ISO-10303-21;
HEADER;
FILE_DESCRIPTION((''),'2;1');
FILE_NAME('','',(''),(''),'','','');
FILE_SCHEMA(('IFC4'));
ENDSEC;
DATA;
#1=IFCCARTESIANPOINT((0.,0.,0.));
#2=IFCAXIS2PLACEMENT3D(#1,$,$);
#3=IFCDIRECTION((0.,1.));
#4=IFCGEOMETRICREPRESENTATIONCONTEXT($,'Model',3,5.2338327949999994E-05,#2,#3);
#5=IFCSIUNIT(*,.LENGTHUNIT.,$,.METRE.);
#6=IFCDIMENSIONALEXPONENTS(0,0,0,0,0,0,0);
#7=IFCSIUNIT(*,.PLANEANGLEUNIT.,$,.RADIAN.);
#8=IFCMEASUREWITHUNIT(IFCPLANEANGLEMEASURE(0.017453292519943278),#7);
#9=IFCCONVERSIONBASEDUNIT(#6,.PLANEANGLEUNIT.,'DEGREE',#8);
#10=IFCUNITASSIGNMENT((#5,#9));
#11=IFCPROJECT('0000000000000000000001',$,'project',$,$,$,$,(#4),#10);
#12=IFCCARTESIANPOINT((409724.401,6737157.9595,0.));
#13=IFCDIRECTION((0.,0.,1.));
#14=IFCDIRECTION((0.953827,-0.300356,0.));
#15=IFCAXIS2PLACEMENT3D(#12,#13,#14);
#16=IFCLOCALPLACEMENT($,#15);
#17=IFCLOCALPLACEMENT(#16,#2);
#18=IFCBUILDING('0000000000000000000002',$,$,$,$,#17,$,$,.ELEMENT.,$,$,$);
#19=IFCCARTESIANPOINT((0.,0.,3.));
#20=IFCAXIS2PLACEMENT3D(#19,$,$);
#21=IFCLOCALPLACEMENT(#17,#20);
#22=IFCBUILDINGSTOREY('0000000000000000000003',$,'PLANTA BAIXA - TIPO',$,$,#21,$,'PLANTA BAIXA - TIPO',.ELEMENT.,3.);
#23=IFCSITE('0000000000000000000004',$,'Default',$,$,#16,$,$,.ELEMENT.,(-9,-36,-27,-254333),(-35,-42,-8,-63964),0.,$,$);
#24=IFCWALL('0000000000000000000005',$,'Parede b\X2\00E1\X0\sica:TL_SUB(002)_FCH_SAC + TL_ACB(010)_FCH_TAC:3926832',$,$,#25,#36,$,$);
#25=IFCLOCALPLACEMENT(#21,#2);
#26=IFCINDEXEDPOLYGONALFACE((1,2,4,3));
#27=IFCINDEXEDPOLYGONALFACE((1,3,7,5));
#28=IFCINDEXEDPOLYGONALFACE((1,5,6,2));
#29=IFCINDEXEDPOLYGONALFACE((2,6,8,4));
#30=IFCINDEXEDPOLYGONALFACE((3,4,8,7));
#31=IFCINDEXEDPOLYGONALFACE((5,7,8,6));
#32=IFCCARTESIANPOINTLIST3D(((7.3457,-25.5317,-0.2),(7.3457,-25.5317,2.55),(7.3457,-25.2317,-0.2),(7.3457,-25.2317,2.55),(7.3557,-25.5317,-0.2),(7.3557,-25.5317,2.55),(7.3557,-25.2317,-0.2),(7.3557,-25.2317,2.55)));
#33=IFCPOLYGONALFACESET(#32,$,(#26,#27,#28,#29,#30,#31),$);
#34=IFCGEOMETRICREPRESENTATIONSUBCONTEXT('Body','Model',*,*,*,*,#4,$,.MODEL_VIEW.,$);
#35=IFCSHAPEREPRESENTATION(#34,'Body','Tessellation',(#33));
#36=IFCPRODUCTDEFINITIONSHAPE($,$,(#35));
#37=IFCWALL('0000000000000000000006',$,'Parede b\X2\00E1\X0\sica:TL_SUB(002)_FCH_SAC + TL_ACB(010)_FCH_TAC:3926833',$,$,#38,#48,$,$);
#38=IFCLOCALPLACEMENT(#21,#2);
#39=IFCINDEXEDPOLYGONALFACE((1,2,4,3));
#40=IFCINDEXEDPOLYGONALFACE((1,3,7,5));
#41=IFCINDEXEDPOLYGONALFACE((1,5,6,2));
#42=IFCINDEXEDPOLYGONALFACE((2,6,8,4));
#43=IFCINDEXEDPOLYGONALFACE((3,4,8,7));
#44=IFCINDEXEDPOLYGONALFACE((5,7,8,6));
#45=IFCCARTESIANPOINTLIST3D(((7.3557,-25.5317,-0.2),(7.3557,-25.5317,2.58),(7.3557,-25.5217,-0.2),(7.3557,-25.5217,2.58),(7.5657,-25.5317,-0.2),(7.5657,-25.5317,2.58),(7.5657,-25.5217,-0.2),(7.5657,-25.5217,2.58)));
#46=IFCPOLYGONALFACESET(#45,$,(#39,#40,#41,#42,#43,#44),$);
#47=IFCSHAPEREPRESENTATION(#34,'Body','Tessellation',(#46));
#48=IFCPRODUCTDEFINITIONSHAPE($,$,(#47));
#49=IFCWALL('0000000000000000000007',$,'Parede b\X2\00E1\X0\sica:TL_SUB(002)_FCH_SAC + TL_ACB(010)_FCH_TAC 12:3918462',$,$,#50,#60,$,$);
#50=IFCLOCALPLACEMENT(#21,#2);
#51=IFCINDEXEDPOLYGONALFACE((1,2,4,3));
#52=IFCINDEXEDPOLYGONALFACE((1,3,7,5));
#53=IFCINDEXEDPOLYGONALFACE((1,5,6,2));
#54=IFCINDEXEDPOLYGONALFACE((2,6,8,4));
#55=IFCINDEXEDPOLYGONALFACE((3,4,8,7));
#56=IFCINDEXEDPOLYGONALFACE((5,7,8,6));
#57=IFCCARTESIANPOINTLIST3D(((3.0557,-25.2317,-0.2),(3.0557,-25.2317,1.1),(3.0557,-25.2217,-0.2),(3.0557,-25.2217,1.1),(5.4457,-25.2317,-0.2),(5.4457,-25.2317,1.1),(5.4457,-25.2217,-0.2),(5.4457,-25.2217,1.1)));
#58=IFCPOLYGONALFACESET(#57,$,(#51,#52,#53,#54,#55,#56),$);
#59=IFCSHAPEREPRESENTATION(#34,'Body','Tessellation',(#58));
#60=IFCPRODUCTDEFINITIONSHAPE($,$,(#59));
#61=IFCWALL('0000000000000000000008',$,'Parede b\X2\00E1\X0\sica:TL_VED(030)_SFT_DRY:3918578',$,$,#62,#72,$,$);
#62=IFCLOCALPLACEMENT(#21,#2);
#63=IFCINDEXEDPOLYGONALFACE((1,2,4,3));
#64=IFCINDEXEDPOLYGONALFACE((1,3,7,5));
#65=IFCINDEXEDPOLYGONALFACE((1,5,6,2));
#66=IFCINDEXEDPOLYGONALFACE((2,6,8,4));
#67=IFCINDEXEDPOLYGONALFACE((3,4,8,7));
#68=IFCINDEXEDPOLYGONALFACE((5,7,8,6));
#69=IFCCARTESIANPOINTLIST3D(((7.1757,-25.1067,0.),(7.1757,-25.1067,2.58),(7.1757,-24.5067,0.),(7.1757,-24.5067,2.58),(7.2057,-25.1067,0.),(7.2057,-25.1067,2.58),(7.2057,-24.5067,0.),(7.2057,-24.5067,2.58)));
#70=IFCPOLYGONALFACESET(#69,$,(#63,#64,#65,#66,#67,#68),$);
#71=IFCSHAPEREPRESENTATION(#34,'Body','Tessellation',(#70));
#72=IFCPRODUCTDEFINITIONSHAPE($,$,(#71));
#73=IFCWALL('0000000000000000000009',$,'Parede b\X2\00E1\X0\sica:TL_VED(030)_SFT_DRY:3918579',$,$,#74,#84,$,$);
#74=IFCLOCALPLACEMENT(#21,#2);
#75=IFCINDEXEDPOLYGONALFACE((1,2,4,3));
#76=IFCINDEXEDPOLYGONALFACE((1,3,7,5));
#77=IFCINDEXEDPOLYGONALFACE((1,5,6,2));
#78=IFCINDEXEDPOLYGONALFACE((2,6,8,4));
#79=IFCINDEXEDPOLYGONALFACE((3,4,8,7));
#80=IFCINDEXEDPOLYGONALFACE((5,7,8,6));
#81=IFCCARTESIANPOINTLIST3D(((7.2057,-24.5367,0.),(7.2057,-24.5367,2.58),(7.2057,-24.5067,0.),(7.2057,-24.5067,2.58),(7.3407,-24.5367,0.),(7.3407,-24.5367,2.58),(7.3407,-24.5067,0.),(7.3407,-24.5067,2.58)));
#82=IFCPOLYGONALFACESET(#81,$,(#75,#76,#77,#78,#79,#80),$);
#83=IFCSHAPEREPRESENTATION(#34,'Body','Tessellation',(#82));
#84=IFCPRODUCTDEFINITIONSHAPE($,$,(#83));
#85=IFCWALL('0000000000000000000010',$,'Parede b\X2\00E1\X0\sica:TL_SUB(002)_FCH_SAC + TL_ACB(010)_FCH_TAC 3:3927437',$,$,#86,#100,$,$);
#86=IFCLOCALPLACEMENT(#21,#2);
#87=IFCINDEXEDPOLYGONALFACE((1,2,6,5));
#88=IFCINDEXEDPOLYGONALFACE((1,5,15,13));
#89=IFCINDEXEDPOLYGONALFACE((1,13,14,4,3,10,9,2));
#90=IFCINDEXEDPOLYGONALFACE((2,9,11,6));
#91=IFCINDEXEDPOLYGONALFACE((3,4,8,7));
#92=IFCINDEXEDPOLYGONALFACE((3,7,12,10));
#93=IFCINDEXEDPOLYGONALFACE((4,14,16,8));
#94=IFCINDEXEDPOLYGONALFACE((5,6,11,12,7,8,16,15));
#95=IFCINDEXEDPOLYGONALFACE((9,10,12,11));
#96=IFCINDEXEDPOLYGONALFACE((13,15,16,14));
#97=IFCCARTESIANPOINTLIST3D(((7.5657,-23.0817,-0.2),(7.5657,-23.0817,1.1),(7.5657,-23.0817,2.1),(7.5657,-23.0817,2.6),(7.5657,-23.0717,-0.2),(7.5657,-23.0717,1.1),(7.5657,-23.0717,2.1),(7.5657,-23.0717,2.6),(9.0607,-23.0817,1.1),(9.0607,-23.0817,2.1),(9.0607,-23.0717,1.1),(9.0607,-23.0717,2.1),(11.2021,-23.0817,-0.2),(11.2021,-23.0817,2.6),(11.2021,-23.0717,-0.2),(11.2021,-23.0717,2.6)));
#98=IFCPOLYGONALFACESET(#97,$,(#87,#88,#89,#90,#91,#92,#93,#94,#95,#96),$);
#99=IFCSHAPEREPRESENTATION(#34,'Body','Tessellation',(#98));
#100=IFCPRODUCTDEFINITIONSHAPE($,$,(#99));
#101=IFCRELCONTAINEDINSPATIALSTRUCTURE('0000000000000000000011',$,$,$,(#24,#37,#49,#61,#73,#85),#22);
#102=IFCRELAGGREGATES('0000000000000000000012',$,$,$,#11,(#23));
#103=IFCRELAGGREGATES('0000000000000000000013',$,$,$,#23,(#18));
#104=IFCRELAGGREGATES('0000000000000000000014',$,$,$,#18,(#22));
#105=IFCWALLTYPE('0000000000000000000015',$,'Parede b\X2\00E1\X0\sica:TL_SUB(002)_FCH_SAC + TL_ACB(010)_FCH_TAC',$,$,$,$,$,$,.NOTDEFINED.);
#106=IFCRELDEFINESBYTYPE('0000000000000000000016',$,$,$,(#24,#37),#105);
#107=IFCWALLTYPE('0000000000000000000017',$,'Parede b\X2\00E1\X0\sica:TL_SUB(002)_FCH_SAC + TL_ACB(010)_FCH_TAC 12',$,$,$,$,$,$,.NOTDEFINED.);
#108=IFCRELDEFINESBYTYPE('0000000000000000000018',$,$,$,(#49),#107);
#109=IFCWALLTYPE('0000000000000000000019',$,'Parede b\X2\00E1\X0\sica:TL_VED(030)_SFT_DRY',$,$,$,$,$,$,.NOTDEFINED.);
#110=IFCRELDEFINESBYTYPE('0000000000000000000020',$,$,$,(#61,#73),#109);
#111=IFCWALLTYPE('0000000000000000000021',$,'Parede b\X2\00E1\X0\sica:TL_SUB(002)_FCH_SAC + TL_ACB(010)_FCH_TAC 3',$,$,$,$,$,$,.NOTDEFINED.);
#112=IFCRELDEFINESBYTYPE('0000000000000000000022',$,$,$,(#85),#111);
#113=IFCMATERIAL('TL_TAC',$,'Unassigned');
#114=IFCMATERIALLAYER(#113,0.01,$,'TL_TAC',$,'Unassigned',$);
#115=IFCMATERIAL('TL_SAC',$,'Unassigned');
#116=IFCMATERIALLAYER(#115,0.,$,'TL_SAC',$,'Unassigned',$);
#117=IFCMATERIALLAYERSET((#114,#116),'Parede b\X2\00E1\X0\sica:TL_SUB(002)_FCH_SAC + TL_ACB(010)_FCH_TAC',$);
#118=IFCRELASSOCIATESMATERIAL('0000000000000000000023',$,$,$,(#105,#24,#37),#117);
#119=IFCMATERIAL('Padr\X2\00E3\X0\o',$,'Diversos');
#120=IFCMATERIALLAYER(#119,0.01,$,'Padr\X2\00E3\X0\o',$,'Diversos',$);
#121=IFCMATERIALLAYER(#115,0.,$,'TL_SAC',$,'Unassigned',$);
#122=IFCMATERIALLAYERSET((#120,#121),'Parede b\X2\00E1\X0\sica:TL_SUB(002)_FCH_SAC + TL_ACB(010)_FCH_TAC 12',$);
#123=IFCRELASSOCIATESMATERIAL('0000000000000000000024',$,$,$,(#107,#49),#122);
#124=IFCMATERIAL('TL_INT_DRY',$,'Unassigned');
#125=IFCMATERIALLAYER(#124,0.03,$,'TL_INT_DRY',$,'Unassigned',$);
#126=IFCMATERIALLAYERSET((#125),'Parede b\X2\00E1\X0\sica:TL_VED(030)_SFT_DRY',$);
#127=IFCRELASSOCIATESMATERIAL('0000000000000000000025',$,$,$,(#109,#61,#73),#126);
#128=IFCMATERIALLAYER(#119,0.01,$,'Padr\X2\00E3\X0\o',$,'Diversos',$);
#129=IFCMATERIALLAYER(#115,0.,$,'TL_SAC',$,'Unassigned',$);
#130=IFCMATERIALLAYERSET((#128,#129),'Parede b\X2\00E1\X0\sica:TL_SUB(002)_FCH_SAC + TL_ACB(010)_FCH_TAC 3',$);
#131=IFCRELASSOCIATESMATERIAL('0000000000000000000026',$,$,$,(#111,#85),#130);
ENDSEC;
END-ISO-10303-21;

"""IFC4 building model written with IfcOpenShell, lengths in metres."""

from ifc_helpers import new_model, entity, si_unit, converted_unit, direction, frame, frame_2d, origin, place, context, subcontext, project, spatial, rectangle, extrude, material, layer, layer_set, layer_usage, type_object, element, save


model = new_model("IFC4")

# Units and contexts
model_context = context("Model", 3, precision=5.2338327949999994e-05, world=origin(), true_north=direction((0.0, 1.0)))
body_context = subcontext(model_context, "Body", "Model", "MODEL_VIEW")
ifc_project = project(units=[si_unit("LENGTHUNIT", "METRE"), converted_unit("PLANEANGLEUNIT", "DEGREE", entity("IfcPlaneAngleMeasure", 0.017453292519943278), si_unit("PLANEANGLEUNIT", "RADIAN"), dimensions=[0, 0, 0, 0, 0, 0, 0])], contexts=[model_context])

# Site, building, storey
site_placement = place(None, frame((409724.401, 6737157.9595, 0.0), z_axis=(0.0, 0.0, 1.0), x_axis=(0.953827, -0.300356, 0.0)))
site = spatial("IfcSite", under=ifc_project, at=site_placement, Name="Default", CompositionType="ELEMENT", RefLatitude=(-9, -36, -27, -254333), RefLongitude=(-35, -42, -8, -63964), RefElevation=0.0)
building_placement = place(site_placement, origin())
building = spatial("IfcBuilding", under=site, at=building_placement, CompositionType="ELEMENT")
storey_placement = place(building_placement, frame((0.0, 0.0, 3.0)))
storey = spatial("IfcBuildingStorey", under=building, at=storey_placement, Name="PLANTA BAIXA - TIPO", LongName="PLANTA BAIXA - TIPO", CompositionType="ELEMENT", Elevation=3.0)

# Shared definitions
ifc_material_1 = material(Name="TL_SAC", Category="Unassigned")

# Shared definitions
ifc_material_2 = material(Name="TL_TAC", Category="Unassigned")
ifc_layer_1 = layer(ifc_material_2, 0.01, Name="TL_TAC", Category="Unassigned")
ifc_layer_2 = layer(ifc_material_1, 0.0, Name="TL_SAC", Category="Unassigned")
ifc_layer_set_1 = layer_set([ifc_layer_1, ifc_layer_2], Name="Parede básica:TL_SUB(002)_FCH_SAC + TL_ACB(010)_FCH_TAC")
wall_type_1 = type_object("IfcWallType", Name="Parede básica:TL_SUB(002)_FCH_SAC + TL_ACB(010)_FCH_TAC", PredefinedType="NOTDEFINED", material=ifc_layer_set_1)

# Walls
ifc_layer_usage_1 = layer_usage(ifc_layer_set_1, "AXIS2", "NEGATIVE", 0.005)
wall_1_placement = place(storey_placement, frame((7.3507, -25.2317, -0.2), z_axis=(0.0, 0.0, 1.0), x_axis=(0.0, -1.0, 0.0)))
element("IfcWall", 1, at=wall_1_placement, inside=storey, type_object=wall_type_1, material=ifc_layer_usage_1, Name="Parede básica:TL_SUB(002)_FCH_SAC + TL_ACB(010)_FCH_TAC:3926832", context=body_context, shape_type="SweptSolid", body=[
    extrude(rectangle(XDim=0.3, YDim=0.01, at=frame_2d((0.15, 0.0), x_axis=(-1.0, 0.0))), origin(), (0.0, 0.0, 1.0), 2.75),
])
ifc_layer_usage_2 = layer_usage(ifc_layer_set_1, "AXIS2", "NEGATIVE", 0.005)
wall_2_placement = place(storey_placement, frame((7.3557, -25.5267, -0.2)))
element("IfcWall", 2, at=wall_2_placement, inside=storey, type_object=wall_type_1, material=ifc_layer_usage_2, Name="Parede básica:TL_SUB(002)_FCH_SAC + TL_ACB(010)_FCH_TAC:3926833", context=body_context, shape_type="SweptSolid", body=[
    extrude(rectangle(XDim=0.21, YDim=0.01, at=frame_2d((0.105, 0.0), x_axis=(-1.0, 0.0))), origin(), (0.0, 0.0, 1.0), 2.78),
])
ifc_material_3 = material(Name="Padrão", Category="Diversos")
ifc_layer_3 = layer(ifc_material_3, 0.01, Name="Padrão", Category="Diversos")
ifc_layer_4 = layer(ifc_material_1, 0.0, Name="TL_SAC", Category="Unassigned")
ifc_layer_set_2 = layer_set([ifc_layer_3, ifc_layer_4], Name="Parede básica:TL_SUB(002)_FCH_SAC + TL_ACB(010)_FCH_TAC 12")
ifc_layer_usage_3 = layer_usage(ifc_layer_set_2, "AXIS2", "POSITIVE", -0.005)
wall_type_2 = type_object("IfcWallType", Name="Parede básica:TL_SUB(002)_FCH_SAC + TL_ACB(010)_FCH_TAC 12", PredefinedType="NOTDEFINED", material=ifc_layer_set_2)
wall_3_placement = place(storey_placement, frame((5.4457, -25.2267, -0.2), z_axis=(0.0, 0.0, 1.0), x_axis=(-1.0, 0.0, 0.0)))
element("IfcWall", 3, at=wall_3_placement, inside=storey, type_object=wall_type_2, material=ifc_layer_usage_3, Name="Parede básica:TL_SUB(002)_FCH_SAC + TL_ACB(010)_FCH_TAC 12:3918462", context=body_context, shape_type="SweptSolid", body=[
    extrude(rectangle(XDim=2.39, YDim=0.01, at=frame_2d((1.195, 0.0), x_axis=(-1.0, 0.0))), origin(), (0.0, 0.0, 1.0), 1.3),
])
ifc_material_4 = material(Name="TL_INT_DRY", Category="Unassigned")
ifc_layer_5 = layer(ifc_material_4, 0.03, Name="TL_INT_DRY", Category="Unassigned")
ifc_layer_set_3 = layer_set([ifc_layer_5], Name="Parede básica:TL_VED(030)_SFT_DRY")
ifc_layer_usage_4 = layer_usage(ifc_layer_set_3, "AXIS2", "NEGATIVE", 0.015)
wall_type_3 = type_object("IfcWallType", Name="Parede básica:TL_VED(030)_SFT_DRY", PredefinedType="NOTDEFINED", material=ifc_layer_set_3)
wall_4_placement = place(storey_placement, frame((7.1907, -25.1067, 0.0), z_axis=(0.0, 0.0, 1.0), x_axis=(0.0, 1.0, 0.0)))
element("IfcWall", 4, at=wall_4_placement, inside=storey, type_object=wall_type_3, material=ifc_layer_usage_4, Name="Parede básica:TL_VED(030)_SFT_DRY:3918578", context=body_context, shape_type="SweptSolid", body=[
    extrude(rectangle(XDim=0.6, YDim=0.03, at=frame_2d((0.3, 0.0), x_axis=(-1.0, 0.0))), origin(), (0.0, 0.0, 1.0), 2.58),
])
ifc_layer_usage_5 = layer_usage(ifc_layer_set_3, "AXIS2", "NEGATIVE", 0.015)
wall_5_placement = place(storey_placement, frame((7.2057, -24.5217, 0.0)))
element("IfcWall", 5, at=wall_5_placement, inside=storey, type_object=wall_type_3, material=ifc_layer_usage_5, Name="Parede básica:TL_VED(030)_SFT_DRY:3918579", context=body_context, shape_type="SweptSolid", body=[
    extrude(rectangle(XDim=0.135, YDim=0.03, at=frame_2d((0.0675, 0.0), x_axis=(-1.0, 0.0))), origin(), (0.0, 0.0, 1.0), 2.58),
])

# Wall, opening
ifc_layer_6 = layer(ifc_material_3, 0.01, Name="Padrão", Category="Diversos")
ifc_layer_7 = layer(ifc_material_1, 0.0, Name="TL_SAC", Category="Unassigned")
ifc_layer_set_4 = layer_set([ifc_layer_6, ifc_layer_7], Name="Parede básica:TL_SUB(002)_FCH_SAC + TL_ACB(010)_FCH_TAC 3")
ifc_layer_usage_6 = layer_usage(ifc_layer_set_4, "AXIS2", "NEGATIVE", 0.005)
wall_type_4 = type_object("IfcWallType", Name="Parede básica:TL_SUB(002)_FCH_SAC + TL_ACB(010)_FCH_TAC 3", PredefinedType="NOTDEFINED", material=ifc_layer_set_4)
wall_6_placement = place(storey_placement, frame((7.5657, -23.0767, -0.2)))
wall_6 = element("IfcWall", 6, at=wall_6_placement, inside=storey, type_object=wall_type_4, material=ifc_layer_usage_6, Name="Parede básica:TL_SUB(002)_FCH_SAC + TL_ACB(010)_FCH_TAC 3:3927437", context=body_context, shape_type="SweptSolid", body=[
    extrude(rectangle(XDim=3.6364, YDim=0.01, at=frame_2d((1.8182, 0.0), x_axis=(-1.0, 0.0))), origin(), (0.0, 0.0, 1.0), 2.8),
])
opening_1_placement = place(wall_6_placement, frame((-7.5657, 23.0767, 1.3)))
element("IfcOpeningElement", 7, at=opening_1_placement, cuts=wall_6, PredefinedType="OPENING", context=body_context, shape_type="SweptSolid", body=[
    extrude(rectangle(XDim=1.0, YDim=1.5, at=frame_2d((0.0, 0.0), x_axis=(1.0, 0.0))), frame((8.3107, -24.4457, 0.5), z_axis=(0.0, 1.0, 0.0), x_axis=(0.0, 0.0, -1.0)), (0.0, 0.0, 1.0), 3.048),
])

save(model, "model.ifc")
